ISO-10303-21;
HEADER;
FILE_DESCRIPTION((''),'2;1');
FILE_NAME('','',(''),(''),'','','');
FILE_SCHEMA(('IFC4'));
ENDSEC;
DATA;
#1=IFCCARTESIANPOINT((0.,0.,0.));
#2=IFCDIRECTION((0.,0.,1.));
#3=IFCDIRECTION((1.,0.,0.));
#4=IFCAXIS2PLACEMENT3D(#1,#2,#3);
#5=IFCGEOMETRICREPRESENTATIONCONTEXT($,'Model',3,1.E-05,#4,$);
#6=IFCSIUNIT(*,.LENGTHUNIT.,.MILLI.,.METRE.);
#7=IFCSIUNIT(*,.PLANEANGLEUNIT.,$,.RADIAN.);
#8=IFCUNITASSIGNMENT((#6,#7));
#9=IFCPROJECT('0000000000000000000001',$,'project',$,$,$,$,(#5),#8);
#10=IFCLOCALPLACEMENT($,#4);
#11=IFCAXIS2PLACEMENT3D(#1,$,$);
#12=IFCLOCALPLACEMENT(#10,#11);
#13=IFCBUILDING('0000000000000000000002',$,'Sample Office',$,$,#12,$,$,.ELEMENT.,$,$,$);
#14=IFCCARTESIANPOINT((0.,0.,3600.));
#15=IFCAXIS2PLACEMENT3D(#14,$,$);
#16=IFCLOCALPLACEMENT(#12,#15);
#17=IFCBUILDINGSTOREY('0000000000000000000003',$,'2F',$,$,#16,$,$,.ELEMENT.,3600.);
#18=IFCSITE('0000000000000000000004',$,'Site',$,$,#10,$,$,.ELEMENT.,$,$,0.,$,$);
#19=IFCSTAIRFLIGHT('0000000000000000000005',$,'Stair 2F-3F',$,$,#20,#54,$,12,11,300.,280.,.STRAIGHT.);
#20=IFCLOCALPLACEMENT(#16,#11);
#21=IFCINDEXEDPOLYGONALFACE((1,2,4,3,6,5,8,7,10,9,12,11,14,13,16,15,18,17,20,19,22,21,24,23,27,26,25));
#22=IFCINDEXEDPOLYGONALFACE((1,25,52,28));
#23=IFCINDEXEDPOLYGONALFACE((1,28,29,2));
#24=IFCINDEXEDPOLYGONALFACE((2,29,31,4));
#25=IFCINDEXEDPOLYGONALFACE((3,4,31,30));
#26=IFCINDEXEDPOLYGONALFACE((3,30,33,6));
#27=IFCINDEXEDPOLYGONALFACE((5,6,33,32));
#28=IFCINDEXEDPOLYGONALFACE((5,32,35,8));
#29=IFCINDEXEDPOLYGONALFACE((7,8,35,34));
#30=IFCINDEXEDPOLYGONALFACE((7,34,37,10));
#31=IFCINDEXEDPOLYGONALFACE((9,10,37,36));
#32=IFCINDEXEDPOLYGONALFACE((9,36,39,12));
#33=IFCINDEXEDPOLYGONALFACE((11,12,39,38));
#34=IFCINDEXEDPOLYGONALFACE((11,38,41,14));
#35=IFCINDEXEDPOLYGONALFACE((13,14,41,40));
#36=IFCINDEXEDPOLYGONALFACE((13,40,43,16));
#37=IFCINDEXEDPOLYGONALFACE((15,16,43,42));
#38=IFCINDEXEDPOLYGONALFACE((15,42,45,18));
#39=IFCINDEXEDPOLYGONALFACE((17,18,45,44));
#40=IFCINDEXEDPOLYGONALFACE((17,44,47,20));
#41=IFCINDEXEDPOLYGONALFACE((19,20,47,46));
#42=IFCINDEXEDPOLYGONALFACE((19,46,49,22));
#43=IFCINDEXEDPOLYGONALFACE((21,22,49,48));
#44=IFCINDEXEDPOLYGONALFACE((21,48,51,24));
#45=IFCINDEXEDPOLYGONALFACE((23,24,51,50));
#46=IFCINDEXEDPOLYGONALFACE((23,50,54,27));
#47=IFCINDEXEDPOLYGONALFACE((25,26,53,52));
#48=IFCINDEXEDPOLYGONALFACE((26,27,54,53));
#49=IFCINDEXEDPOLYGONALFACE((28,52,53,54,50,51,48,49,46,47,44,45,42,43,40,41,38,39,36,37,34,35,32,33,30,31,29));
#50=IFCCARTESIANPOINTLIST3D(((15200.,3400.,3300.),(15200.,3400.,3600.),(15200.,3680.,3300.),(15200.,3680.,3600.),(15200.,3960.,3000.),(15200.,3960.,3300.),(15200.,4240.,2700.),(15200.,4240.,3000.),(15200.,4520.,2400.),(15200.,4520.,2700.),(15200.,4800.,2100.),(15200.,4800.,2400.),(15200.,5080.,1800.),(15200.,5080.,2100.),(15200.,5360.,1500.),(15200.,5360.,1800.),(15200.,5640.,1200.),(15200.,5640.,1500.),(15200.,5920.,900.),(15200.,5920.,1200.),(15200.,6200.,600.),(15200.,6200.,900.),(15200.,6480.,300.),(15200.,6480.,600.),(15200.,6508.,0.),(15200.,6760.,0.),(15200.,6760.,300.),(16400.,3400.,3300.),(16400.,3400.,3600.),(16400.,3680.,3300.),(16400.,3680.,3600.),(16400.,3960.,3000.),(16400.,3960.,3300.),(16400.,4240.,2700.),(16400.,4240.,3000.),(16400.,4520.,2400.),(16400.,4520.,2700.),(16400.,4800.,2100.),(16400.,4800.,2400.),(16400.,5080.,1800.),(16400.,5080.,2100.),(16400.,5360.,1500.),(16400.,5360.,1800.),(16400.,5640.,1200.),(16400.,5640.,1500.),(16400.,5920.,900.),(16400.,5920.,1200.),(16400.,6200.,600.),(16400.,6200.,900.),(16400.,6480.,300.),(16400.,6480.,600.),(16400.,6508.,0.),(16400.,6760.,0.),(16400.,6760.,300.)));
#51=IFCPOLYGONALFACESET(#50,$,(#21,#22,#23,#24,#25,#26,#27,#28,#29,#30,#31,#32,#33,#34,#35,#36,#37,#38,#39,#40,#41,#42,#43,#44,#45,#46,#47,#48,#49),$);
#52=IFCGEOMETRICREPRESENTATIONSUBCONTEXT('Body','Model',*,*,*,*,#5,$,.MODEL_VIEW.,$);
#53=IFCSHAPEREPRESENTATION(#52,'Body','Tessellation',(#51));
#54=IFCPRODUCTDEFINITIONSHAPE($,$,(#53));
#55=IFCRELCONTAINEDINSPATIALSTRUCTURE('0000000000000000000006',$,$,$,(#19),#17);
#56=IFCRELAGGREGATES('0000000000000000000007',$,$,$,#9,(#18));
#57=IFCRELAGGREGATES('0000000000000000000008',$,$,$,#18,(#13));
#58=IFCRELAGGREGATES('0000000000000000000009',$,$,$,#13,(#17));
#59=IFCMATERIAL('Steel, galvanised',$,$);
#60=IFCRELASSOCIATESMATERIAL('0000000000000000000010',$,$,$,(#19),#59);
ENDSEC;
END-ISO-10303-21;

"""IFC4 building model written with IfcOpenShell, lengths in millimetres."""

from ifc_helpers import new_model, si_unit, frame, origin, origin_with_axes, place, context, subcontext, project, spatial, polyline, outline, extrude, material, element, save


model = new_model("IFC4")

# Units and contexts
model_context = context("Model", 3, precision=1e-05, world=origin_with_axes())
body_context = subcontext(model_context, "Body", "Model", "MODEL_VIEW")
ifc_project = project(units=[si_unit("LENGTHUNIT", "METRE", prefix="MILLI"), si_unit("PLANEANGLEUNIT", "RADIAN")], contexts=[model_context])

# Site, building, storey
site_placement = place(None, origin_with_axes())
site = spatial("IfcSite", under=ifc_project, at=site_placement, Name="Site", CompositionType="ELEMENT", RefElevation=0.0)
building_placement = place(site_placement, origin())
building = spatial("IfcBuilding", under=site, at=building_placement, Name="Sample Office", CompositionType="ELEMENT")
storey_placement = place(building_placement, frame((0.0, 0.0, 3600.0)))
storey = spatial("IfcBuildingStorey", under=building, at=storey_placement, Name="2F", CompositionType="ELEMENT", Elevation=3600.0)

# Stair flight
ifc_material_1 = material(Name="Steel, galvanised")
stair_flight_placement = place(storey_placement, frame((15200.0, 6760.0, 0.0)))
element("IfcStairFlight", 1, at=stair_flight_placement, inside=storey, material=ifc_material_1, Name="Stair 2F-3F", NumberOfRisers=12, NumberOfTreads=11, PredefinedType="STRAIGHT", RiserHeight=300.0, TreadLength=280.0, context=body_context, shape_type="SweptSolid", body=[
    extrude(outline(polyline([(0.0, 0.0), (0.0, 300.0), (280.0, 300.0), (280.0, 600.0), (560.0, 600.0), (560.0, 900.0), (840.0, 900.0), (840.0, 1200.0), (1120.0, 1200.0), (1120.0, 1500.0), (1400.0, 1500.0), (1400.0, 1800.0), (1680.0, 1800.0), (1680.0, 2100.0), (1960.0, 2100.0), (1960.0, 2400.0), (2240.0, 2400.0), (2240.0, 2700.0), (2520.0, 2700.0), (2520.0, 3000.0), (2800.0, 3000.0), (2800.0, 3300.0), (3080.0, 3300.0), (3080.0, 3600.0), (3360.0, 3600.0), (3360.0, 3300.0), (252.0, 0.0), (0.0, 0.0)])), frame((1200.0, 0.0, 0.0), z_axis=(-1.0, 0.0, 0.0), x_axis=(0.0, -1.0, 0.0)), (0.0, 0.0, 1.0), 1200.0),
])

save(model, "model.ifc")
